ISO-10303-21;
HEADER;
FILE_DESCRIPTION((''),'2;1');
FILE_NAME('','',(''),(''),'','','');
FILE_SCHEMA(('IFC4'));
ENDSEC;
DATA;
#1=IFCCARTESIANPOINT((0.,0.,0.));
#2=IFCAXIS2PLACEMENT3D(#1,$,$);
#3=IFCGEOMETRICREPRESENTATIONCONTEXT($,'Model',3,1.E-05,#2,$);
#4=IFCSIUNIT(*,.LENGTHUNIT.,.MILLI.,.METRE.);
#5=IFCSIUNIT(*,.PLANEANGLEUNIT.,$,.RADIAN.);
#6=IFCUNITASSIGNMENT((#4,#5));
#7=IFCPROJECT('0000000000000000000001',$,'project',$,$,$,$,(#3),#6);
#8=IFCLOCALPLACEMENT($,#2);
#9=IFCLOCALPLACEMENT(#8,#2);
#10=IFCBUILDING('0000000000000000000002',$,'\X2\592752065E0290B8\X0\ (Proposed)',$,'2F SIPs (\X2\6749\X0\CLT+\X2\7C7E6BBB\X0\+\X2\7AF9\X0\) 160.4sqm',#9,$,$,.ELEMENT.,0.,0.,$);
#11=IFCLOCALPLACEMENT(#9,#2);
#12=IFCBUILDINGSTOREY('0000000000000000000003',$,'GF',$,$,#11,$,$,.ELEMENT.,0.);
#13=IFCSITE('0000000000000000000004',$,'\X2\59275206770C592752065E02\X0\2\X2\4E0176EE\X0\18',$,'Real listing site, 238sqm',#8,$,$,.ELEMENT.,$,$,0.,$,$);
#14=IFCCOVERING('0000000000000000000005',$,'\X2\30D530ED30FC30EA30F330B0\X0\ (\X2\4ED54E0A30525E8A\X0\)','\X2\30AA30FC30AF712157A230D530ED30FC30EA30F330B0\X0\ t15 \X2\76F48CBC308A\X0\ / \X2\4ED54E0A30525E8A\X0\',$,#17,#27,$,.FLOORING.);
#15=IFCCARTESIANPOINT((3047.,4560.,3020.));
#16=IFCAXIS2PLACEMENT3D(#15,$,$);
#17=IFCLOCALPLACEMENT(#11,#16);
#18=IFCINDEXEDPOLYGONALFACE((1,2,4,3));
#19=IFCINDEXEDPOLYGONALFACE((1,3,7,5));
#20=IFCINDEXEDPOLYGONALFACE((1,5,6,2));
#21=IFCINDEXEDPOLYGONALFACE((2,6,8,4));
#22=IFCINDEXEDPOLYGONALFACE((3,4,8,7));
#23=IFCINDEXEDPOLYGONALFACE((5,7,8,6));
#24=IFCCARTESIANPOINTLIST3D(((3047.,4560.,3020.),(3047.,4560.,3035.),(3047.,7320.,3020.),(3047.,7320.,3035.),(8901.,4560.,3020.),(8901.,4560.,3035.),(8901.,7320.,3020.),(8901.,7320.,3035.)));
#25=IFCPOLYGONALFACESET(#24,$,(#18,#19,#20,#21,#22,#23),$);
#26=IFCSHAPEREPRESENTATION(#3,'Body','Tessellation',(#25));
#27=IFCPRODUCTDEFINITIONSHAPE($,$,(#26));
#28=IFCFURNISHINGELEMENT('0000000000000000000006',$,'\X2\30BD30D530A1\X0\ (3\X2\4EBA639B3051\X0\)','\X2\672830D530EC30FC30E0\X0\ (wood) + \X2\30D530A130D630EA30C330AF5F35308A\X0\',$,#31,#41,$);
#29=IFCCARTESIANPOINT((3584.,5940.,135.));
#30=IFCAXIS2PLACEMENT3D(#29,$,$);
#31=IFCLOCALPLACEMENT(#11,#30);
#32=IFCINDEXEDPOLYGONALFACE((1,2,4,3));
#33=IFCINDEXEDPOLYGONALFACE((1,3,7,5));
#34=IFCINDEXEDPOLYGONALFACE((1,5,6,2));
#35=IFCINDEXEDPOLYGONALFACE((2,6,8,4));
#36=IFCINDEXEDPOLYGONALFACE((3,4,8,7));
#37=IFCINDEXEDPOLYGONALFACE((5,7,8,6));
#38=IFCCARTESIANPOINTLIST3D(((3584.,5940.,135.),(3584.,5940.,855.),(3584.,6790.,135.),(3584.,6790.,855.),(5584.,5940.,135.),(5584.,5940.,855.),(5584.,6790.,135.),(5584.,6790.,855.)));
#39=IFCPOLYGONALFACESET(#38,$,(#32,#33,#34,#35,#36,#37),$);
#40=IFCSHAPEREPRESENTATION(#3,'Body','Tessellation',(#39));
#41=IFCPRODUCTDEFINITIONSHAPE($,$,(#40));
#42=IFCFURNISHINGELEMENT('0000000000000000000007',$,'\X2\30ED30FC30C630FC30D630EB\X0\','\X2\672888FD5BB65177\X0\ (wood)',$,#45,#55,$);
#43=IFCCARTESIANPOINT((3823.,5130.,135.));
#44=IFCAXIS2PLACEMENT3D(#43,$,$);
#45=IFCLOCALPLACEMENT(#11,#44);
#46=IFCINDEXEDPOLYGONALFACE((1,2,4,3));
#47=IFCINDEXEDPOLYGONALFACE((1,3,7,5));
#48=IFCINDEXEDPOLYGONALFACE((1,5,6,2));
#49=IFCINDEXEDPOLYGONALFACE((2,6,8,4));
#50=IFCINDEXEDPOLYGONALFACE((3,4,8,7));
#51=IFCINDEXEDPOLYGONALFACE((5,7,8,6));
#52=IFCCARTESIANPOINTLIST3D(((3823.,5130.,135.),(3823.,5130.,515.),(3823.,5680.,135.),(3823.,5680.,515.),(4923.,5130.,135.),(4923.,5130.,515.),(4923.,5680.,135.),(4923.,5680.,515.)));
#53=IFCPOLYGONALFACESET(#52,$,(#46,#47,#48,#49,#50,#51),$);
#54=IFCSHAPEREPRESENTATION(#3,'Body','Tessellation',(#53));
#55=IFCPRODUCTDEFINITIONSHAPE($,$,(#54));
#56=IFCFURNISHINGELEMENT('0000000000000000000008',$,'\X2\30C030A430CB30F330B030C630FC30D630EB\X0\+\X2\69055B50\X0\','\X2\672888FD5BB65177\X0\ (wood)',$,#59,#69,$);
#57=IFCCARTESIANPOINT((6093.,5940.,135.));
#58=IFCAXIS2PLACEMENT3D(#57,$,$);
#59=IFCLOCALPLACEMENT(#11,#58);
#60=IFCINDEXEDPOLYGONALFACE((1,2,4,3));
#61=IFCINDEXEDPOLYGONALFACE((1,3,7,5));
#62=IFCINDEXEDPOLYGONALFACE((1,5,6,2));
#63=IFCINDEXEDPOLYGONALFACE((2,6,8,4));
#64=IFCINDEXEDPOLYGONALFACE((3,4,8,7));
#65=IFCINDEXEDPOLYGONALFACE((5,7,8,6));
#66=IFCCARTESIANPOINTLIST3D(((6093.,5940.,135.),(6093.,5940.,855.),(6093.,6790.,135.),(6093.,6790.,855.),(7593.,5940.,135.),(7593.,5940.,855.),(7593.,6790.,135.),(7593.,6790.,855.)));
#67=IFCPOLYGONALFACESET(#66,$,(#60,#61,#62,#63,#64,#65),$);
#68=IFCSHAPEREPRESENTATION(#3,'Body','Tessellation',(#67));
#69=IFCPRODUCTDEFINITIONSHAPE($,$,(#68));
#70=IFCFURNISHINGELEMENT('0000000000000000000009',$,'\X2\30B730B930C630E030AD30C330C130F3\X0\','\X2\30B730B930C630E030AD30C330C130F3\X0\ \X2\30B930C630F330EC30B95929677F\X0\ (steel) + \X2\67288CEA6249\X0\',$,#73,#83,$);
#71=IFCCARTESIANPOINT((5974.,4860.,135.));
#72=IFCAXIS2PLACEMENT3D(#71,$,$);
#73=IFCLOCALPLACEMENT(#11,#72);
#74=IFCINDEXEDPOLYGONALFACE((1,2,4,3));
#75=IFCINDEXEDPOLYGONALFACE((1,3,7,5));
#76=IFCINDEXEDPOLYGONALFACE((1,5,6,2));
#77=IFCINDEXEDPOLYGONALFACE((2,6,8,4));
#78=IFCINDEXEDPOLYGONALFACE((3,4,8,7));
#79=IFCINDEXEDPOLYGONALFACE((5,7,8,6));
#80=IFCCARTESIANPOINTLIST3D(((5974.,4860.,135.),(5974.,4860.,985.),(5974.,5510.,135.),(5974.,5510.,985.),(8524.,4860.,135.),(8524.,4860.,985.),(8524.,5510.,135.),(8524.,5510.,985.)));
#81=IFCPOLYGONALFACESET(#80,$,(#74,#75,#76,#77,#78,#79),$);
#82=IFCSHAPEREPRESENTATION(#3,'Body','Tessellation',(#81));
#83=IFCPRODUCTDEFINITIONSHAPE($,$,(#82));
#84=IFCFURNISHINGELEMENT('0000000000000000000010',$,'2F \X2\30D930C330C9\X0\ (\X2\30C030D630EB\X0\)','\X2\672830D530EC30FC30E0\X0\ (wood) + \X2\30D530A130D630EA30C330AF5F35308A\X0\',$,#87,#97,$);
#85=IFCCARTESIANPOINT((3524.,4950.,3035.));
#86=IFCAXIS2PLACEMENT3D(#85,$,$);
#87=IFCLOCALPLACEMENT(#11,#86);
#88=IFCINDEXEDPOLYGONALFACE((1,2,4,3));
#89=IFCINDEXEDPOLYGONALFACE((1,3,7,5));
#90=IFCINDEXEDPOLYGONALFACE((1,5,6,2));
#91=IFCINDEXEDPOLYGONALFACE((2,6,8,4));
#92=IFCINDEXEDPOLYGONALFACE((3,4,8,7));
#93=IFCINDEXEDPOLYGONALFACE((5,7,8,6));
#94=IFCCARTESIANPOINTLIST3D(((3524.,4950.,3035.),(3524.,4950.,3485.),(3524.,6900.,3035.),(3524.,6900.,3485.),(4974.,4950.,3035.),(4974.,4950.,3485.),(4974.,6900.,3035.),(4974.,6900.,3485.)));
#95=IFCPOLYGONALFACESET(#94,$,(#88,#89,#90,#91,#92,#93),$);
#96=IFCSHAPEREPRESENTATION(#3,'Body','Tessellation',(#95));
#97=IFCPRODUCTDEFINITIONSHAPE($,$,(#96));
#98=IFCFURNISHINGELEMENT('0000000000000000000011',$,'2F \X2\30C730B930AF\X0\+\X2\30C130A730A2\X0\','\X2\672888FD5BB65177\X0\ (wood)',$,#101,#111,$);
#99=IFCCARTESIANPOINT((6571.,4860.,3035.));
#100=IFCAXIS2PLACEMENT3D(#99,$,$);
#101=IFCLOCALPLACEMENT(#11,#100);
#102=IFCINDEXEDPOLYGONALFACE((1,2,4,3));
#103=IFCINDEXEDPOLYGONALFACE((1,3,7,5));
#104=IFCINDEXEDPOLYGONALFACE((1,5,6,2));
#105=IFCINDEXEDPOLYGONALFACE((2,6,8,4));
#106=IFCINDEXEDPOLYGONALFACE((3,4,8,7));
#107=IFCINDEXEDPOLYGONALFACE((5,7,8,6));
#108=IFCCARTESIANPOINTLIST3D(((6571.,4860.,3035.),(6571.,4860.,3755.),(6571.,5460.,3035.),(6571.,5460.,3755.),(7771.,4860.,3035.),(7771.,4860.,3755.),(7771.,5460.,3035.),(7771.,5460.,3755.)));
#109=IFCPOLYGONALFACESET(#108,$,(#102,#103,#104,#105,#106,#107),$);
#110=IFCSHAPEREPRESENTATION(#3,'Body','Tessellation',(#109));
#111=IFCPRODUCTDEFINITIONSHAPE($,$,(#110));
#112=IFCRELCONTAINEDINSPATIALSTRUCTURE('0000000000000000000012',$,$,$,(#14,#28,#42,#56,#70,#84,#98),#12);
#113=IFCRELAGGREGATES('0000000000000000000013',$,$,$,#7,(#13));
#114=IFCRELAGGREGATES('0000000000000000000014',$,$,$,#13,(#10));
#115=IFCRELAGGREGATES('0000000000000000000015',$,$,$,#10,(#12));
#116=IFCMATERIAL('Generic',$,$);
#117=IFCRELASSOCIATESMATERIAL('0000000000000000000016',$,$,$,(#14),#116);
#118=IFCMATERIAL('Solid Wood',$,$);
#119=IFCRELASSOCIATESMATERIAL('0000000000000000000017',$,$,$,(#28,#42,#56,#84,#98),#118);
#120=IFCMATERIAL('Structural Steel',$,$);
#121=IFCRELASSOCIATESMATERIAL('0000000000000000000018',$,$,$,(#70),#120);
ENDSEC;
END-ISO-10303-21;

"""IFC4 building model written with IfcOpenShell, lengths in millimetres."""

from ifc_helpers import new_model, si_unit, frame, frame_2d, origin, place, context, project, spatial, rectangle, extrude, material, element, save


model = new_model("IFC4")

# Units and contexts
model_context = context("Model", 3, precision=1e-05, world=origin())
ifc_project = project(units=[si_unit("LENGTHUNIT", "METRE", prefix="MILLI"), si_unit("PLANEANGLEUNIT", "RADIAN")], contexts=[model_context])

# Site, building, storey
site_placement = place(None, origin())
site = spatial("IfcSite", under=ifc_project, at=site_placement, Name="大分県大分市2丁目18", ObjectType="Real listing site, 238sqm", CompositionType="ELEMENT", RefElevation=0.0)
building_placement = place(site_placement, origin())
building = spatial("IfcBuilding", under=site, at=building_placement, Name="大分市邸 (Proposed)", ObjectType="2F SIPs (杉CLT+籾殻+竹) 160.4sqm", CompositionType="ELEMENT", ElevationOfRefHeight=0.0, ElevationOfTerrain=0.0)
storey_placement = place(building_placement, origin())
storey = spatial("IfcBuildingStorey", under=building, at=storey_placement, Name="GF", CompositionType="ELEMENT", Elevation=0.0)

# Shared definitions
ifc_material_1 = material(Name="Solid Wood")

# Shared definitions
ifc_material_2 = material(Name="Generic")

# Shared definitions
ifc_material_3 = material(Name="Structural Steel")

# Covering
covering_placement = place(storey_placement, frame((3047.0, 4560.0, 3020.0)))
element("IfcCovering", 1, at=covering_placement, inside=storey, material=ifc_material_2, Name="フローリング (仕上げ床)", Description="オーク無垢フローリング t15 直貼り / 仕上げ床", PredefinedType="FLOORING", context=model_context, shape_type="SweptSolid", body=[
    extrude(rectangle(XDim=5854.0, YDim=2760.0, at=frame_2d((2927.0, 1380.0))), frame((3047.0, 4560.0, 3020.0)), (0.0, 0.0, 1.0), 15.0),
])

# Furnishing elements
furnishing_1_placement = place(storey_placement, frame((3584.0, 5940.0, 135.0)))
element("IfcFurnishingElement", 2, at=furnishing_1_placement, inside=storey, material=ifc_material_1, Name="ソファ (3人掛け)", Description="木フレーム (wood) + ファブリック張り", context=model_context, shape_type="SweptSolid", body=[
    extrude(rectangle(XDim=2000.0, YDim=850.0, at=frame_2d((1000.0, 425.0))), frame((3584.0, 5940.0, 135.0)), (0.0, 0.0, 1.0), 720.0),
])
furnishing_2_placement = place(storey_placement, frame((3823.0, 5130.0, 135.0)))
element("IfcFurnishingElement", 3, at=furnishing_2_placement, inside=storey, material=ifc_material_1, Name="ローテーブル", Description="木製家具 (wood)", context=model_context, shape_type="SweptSolid", body=[
    extrude(rectangle(XDim=1100.0, YDim=550.0, at=frame_2d((550.0, 275.0))), frame((3823.0, 5130.0, 135.0)), (0.0, 0.0, 1.0), 380.0),
])
furnishing_3_placement = place(storey_placement, frame((6093.0, 5940.0, 135.0)))
element("IfcFurnishingElement", 4, at=furnishing_3_placement, inside=storey, material=ifc_material_1, Name="ダイニングテーブル+椅子", Description="木製家具 (wood)", context=model_context, shape_type="SweptSolid", body=[
    extrude(rectangle(XDim=1500.0, YDim=850.0, at=frame_2d((750.0, 425.0))), frame((6093.0, 5940.0, 135.0)), (0.0, 0.0, 1.0), 720.0),
])
furnishing_4_placement = place(storey_placement, frame((5974.0, 4860.0, 135.0)))
element("IfcFurnishingElement", 5, at=furnishing_4_placement, inside=storey, material=ifc_material_3, Name="システムキッチン", Description="システムキッチン ステンレス天板 (steel) + 木質扉", context=model_context, shape_type="SweptSolid", body=[
    extrude(rectangle(XDim=2550.0, YDim=650.0, at=frame_2d((1275.0, 325.0))), frame((5974.0, 4860.0, 135.0)), (0.0, 0.0, 1.0), 850.0),
])
furnishing_5_placement = place(storey_placement, frame((3524.0, 4950.0, 3035.0)))
element("IfcFurnishingElement", 6, at=furnishing_5_placement, inside=storey, material=ifc_material_1, Name="2F ベッド (ダブル)", Description="木フレーム (wood) + ファブリック張り", context=model_context, shape_type="SweptSolid", body=[
    extrude(rectangle(XDim=1450.0, YDim=1950.0, at=frame_2d((725.0, 975.0))), frame((3524.0, 4950.0, 3035.0)), (0.0, 0.0, 1.0), 450.0),
])
furnishing_6_placement = place(storey_placement, frame((6571.0, 4860.0, 3035.0)))
element("IfcFurnishingElement", 7, at=furnishing_6_placement, inside=storey, material=ifc_material_1, Name="2F デスク+チェア", Description="木製家具 (wood)", context=model_context, shape_type="SweptSolid", body=[
    extrude(rectangle(XDim=1200.0, YDim=600.0, at=frame_2d((600.0, 300.0))), frame((6571.0, 4860.0, 3035.0)), (0.0, 0.0, 1.0), 720.0),
])

save(model, "model.ifc")
